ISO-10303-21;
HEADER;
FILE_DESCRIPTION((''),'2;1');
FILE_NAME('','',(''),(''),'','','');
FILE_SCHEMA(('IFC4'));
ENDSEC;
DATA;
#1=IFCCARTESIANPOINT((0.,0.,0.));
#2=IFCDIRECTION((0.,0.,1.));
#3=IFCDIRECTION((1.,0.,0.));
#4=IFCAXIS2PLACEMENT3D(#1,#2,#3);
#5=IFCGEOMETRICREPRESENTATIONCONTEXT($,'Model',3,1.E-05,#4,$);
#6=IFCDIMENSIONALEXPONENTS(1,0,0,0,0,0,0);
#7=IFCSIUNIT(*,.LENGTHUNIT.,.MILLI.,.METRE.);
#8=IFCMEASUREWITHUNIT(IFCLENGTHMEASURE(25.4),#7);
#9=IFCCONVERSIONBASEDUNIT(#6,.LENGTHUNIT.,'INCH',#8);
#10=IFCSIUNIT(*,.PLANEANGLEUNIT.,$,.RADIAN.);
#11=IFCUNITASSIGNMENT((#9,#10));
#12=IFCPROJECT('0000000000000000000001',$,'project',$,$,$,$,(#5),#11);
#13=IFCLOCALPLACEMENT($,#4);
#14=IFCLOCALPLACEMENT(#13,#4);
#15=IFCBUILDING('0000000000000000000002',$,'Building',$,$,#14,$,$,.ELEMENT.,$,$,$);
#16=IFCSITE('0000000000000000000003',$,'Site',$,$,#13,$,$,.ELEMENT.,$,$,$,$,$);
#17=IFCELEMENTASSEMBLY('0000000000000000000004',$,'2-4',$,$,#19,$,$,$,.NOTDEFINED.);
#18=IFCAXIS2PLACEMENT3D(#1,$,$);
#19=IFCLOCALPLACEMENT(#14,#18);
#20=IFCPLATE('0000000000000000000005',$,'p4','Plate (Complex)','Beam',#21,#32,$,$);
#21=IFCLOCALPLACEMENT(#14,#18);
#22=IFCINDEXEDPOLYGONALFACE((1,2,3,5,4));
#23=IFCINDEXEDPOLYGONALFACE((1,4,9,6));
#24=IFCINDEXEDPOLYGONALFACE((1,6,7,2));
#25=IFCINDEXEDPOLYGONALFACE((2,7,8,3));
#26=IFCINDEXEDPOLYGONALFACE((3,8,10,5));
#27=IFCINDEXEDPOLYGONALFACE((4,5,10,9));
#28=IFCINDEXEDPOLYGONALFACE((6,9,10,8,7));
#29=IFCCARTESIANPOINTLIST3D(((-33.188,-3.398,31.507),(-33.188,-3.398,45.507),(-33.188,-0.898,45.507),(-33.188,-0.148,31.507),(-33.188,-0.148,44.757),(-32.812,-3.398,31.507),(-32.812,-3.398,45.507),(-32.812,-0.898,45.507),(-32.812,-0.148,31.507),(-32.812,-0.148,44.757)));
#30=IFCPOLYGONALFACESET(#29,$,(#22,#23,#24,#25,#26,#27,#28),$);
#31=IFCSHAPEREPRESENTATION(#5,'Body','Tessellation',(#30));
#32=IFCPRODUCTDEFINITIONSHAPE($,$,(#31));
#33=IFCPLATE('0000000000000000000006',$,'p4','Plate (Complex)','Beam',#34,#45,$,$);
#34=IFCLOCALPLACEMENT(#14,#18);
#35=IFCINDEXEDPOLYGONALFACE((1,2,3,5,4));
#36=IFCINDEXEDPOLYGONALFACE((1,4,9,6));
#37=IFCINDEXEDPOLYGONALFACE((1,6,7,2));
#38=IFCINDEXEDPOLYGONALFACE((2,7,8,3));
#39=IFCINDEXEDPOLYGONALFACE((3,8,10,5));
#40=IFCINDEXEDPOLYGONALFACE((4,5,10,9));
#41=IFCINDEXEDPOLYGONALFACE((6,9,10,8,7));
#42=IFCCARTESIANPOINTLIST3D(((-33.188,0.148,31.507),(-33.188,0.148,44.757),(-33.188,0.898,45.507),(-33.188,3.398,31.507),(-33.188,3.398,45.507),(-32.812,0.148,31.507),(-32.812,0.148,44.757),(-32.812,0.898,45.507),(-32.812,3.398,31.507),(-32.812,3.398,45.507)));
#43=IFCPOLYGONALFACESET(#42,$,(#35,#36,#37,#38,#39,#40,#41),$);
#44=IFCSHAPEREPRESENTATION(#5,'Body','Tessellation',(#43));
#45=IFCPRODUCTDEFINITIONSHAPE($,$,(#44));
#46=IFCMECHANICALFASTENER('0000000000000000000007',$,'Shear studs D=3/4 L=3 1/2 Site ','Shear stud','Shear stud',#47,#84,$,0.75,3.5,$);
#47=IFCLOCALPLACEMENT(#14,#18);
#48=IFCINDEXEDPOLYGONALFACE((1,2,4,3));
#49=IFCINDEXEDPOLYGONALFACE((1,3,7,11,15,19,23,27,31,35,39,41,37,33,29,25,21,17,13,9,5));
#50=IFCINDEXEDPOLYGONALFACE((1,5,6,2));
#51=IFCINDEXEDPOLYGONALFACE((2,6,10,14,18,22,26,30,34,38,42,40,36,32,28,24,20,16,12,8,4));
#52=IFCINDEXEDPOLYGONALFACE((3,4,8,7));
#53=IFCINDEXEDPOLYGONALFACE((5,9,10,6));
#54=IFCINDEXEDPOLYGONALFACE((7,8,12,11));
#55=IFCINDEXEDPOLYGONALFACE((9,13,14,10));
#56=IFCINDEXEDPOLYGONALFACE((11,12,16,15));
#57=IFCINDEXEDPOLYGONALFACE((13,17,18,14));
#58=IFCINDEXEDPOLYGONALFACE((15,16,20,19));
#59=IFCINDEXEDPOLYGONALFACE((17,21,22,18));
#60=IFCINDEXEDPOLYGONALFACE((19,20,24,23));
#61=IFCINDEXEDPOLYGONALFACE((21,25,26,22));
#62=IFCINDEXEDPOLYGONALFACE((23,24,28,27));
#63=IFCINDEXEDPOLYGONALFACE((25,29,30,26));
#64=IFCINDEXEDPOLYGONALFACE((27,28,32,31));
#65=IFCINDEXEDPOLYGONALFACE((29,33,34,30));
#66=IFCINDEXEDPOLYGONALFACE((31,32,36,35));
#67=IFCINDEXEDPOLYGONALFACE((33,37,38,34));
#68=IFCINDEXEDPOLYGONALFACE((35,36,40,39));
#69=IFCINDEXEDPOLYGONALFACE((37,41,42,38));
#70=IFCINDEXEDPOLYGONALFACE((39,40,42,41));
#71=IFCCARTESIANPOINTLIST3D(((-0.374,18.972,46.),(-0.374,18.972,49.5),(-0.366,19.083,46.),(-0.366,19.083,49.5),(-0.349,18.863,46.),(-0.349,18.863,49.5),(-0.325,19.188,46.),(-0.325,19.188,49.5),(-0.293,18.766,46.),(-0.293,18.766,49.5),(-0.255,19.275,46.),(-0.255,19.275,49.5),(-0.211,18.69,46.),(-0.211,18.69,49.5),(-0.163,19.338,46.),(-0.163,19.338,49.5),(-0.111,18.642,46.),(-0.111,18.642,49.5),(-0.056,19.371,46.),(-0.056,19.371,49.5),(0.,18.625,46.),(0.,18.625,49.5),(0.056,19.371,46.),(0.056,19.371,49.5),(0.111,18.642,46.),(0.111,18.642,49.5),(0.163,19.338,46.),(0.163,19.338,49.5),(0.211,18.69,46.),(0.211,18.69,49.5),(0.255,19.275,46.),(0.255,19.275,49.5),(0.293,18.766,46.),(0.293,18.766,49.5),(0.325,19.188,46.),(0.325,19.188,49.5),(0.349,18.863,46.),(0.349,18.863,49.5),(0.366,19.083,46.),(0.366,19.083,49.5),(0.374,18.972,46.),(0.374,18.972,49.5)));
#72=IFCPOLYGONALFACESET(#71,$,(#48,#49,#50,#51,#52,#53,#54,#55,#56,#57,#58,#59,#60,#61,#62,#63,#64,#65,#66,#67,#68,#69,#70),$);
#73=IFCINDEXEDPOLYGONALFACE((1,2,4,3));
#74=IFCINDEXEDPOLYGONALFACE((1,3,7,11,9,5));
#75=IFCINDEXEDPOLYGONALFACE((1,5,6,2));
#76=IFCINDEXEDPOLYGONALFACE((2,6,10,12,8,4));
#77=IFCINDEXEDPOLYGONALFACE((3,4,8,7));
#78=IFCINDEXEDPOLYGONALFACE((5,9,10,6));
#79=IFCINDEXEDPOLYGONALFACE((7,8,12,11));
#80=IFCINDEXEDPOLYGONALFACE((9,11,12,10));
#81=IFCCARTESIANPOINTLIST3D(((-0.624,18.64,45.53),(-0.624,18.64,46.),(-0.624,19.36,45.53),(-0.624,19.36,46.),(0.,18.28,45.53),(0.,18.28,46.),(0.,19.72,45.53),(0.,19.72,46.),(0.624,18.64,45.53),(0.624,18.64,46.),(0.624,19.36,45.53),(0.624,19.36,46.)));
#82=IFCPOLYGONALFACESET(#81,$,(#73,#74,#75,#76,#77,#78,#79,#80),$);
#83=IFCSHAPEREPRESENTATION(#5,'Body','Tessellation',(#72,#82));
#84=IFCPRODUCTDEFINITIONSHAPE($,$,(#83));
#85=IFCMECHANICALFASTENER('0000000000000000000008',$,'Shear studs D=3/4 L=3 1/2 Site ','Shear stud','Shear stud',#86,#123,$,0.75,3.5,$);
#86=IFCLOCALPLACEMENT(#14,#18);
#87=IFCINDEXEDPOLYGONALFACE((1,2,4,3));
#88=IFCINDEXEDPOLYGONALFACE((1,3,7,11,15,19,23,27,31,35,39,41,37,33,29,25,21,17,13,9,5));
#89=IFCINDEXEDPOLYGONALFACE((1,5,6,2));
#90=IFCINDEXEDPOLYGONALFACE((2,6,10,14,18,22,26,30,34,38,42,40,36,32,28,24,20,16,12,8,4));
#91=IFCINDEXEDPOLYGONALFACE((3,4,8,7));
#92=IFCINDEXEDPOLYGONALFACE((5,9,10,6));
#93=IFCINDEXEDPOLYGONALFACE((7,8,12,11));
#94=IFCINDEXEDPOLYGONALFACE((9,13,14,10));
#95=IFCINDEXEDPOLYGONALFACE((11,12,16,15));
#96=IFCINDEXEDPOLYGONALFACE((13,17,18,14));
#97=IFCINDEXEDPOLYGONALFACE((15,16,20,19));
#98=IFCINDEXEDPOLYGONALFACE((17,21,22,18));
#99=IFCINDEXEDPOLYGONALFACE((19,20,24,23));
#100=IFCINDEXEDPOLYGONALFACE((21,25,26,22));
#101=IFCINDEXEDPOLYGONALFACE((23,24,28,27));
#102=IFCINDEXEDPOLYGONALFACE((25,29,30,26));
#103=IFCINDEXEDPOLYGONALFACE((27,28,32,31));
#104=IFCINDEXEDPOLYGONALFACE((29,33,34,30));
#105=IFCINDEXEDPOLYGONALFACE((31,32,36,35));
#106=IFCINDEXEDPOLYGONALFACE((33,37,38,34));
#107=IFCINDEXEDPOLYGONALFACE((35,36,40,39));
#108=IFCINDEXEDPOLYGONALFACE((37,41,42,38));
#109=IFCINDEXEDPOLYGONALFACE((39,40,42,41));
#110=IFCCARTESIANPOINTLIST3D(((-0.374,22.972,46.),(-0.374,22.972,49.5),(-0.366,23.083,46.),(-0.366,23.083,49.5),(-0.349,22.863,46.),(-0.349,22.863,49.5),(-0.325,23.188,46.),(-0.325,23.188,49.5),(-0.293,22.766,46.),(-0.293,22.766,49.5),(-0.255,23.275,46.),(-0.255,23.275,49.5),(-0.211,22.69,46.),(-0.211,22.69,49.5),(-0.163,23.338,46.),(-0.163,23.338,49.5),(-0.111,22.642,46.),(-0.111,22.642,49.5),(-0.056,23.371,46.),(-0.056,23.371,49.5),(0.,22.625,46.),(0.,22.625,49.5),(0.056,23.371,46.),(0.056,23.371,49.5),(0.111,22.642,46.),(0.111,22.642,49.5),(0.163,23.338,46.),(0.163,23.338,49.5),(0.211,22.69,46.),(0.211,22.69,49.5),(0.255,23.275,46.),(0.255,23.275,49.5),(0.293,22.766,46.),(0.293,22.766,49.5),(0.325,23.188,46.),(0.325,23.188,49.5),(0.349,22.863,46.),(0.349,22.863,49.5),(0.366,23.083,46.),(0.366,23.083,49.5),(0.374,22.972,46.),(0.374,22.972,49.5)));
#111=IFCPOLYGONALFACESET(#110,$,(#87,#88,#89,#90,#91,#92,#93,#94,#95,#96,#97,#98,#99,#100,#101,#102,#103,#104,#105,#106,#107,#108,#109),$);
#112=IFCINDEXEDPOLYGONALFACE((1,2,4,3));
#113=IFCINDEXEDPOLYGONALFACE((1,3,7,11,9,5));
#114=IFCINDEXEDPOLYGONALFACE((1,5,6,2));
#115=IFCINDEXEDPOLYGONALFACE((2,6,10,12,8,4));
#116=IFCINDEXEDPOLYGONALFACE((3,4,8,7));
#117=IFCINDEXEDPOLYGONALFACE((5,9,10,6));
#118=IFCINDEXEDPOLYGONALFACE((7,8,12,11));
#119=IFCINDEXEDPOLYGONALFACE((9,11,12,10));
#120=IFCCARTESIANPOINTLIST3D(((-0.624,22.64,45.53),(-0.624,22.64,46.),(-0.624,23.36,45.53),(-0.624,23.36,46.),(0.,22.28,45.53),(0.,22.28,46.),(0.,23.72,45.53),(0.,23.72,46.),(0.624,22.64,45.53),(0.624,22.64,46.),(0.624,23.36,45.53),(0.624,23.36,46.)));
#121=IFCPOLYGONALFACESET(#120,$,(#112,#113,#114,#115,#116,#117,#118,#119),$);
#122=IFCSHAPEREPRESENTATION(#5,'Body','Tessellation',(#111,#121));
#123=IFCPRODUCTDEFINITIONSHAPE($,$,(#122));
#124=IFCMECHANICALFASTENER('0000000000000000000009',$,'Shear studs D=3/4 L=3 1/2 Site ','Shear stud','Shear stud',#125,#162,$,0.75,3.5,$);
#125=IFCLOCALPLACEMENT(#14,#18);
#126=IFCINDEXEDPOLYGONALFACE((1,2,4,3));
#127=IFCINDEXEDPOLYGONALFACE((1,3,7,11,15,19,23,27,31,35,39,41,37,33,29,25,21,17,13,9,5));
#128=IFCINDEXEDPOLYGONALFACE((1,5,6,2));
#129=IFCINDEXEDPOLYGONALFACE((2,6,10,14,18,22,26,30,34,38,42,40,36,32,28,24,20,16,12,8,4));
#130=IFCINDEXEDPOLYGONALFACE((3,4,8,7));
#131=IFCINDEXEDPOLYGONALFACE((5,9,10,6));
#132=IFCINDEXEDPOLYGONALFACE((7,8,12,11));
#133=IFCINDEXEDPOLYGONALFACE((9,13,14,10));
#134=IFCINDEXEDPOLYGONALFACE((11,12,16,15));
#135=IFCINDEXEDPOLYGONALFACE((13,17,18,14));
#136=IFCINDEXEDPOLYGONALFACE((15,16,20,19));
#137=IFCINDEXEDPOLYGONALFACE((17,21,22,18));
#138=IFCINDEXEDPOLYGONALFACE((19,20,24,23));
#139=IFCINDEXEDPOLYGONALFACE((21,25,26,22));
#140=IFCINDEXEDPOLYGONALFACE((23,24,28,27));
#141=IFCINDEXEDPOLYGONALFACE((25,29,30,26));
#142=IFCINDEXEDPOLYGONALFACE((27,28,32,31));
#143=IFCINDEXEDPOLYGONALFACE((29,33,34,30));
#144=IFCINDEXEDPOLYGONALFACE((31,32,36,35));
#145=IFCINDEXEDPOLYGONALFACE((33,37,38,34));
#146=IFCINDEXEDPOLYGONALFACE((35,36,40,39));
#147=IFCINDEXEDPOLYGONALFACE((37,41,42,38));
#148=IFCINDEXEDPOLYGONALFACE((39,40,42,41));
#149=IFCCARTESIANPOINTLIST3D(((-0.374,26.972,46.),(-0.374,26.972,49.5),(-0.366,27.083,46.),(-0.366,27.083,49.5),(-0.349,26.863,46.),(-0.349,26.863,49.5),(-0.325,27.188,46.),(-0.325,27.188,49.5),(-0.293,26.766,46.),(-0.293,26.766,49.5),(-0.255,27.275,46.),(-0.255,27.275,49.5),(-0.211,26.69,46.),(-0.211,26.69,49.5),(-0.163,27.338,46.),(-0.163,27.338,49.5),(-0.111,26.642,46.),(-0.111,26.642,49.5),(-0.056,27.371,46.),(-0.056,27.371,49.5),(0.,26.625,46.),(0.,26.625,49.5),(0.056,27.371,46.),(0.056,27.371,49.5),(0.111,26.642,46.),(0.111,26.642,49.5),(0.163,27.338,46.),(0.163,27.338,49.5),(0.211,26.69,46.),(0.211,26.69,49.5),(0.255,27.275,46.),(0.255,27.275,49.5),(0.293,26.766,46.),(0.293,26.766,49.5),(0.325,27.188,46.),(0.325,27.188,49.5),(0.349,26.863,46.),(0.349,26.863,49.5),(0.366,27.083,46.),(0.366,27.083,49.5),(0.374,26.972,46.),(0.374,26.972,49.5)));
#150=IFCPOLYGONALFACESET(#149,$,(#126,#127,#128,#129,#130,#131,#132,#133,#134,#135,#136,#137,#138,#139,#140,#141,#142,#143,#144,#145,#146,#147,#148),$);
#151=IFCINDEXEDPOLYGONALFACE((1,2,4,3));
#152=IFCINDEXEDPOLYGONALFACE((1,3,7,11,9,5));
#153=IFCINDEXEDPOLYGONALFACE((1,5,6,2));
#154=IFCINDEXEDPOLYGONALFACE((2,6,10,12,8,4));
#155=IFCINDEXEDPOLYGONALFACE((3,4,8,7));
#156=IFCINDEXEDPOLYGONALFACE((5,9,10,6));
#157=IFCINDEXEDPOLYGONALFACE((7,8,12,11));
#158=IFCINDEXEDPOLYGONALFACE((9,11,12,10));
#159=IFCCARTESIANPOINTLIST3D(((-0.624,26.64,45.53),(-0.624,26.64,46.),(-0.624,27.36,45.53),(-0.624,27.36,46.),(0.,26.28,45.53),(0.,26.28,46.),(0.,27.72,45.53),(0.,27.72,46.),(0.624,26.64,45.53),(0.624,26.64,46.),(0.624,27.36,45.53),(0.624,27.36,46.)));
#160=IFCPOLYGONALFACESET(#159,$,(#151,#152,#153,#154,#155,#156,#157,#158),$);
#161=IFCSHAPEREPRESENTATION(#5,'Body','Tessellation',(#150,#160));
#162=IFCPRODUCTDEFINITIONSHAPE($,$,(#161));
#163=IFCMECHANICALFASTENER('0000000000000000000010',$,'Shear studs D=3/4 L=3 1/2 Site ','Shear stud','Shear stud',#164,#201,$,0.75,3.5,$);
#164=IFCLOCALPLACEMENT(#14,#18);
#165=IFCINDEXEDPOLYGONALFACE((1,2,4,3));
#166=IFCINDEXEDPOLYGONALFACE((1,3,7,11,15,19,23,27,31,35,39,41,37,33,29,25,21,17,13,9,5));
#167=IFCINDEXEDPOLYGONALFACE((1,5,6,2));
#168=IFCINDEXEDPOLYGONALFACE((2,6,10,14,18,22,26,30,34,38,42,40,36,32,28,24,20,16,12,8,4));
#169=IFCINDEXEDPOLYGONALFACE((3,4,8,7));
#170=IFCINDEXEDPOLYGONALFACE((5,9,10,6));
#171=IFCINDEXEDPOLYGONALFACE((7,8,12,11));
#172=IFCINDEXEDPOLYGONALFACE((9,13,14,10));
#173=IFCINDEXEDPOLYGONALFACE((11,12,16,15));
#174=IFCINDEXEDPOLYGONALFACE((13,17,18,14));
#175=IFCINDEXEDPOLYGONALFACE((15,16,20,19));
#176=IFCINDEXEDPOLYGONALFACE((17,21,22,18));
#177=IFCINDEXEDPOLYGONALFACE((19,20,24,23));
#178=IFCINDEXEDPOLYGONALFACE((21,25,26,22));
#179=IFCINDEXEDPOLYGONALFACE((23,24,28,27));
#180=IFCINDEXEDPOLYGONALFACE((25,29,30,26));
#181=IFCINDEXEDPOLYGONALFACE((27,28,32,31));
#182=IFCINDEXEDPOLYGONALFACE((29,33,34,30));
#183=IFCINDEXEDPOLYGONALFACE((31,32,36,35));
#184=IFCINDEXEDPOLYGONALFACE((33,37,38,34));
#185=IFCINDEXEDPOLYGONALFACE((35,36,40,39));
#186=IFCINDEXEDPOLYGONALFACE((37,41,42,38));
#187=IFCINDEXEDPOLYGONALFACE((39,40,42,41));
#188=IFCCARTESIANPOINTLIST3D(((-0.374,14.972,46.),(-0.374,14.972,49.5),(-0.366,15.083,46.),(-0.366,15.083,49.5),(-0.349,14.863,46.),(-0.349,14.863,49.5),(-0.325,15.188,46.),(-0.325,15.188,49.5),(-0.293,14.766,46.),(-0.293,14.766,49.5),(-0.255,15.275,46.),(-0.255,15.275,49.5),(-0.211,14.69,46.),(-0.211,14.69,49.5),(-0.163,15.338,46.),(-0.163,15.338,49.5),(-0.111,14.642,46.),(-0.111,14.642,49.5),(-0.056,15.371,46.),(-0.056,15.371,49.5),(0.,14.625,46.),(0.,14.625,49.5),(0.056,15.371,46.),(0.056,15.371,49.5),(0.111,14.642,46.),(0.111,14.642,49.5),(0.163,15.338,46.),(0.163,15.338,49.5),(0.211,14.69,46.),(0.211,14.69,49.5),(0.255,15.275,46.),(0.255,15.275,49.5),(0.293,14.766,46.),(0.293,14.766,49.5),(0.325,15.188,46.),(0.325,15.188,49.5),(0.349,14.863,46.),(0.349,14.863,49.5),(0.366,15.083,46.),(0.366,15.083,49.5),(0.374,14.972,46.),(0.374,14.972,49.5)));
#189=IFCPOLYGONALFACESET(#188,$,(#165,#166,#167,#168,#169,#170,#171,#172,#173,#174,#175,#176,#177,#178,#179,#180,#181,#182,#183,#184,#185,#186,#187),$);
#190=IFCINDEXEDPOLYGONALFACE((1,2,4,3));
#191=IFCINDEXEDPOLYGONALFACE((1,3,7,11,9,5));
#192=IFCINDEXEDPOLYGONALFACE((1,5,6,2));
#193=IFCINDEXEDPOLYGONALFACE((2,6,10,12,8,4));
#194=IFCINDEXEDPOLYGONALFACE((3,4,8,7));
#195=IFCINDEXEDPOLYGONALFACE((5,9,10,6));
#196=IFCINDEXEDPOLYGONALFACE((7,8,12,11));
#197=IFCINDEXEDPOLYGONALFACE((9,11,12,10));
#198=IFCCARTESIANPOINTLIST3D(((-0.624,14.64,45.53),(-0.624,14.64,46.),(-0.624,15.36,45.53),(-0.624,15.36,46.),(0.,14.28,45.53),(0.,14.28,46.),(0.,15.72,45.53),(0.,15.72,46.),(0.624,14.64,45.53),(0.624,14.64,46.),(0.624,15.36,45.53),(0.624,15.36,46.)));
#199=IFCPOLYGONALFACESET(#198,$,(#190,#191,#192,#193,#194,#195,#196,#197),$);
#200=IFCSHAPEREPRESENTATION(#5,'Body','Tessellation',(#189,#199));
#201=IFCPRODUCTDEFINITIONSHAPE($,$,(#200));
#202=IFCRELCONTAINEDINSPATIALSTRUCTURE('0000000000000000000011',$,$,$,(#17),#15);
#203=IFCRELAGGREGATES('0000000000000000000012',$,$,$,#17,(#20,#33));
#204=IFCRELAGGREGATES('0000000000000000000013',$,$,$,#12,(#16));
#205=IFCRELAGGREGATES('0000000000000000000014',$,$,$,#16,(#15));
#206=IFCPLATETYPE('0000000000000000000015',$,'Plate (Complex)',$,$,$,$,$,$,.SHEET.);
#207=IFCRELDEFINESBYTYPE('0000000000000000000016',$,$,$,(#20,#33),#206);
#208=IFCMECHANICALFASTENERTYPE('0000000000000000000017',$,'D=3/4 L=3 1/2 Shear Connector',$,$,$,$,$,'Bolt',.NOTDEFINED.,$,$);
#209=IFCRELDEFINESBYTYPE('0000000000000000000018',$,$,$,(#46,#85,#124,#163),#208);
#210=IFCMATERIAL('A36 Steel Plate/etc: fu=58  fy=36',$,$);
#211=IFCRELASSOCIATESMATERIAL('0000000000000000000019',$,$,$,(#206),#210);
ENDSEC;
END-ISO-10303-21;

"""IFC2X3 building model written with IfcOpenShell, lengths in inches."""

from ifc_helpers import new_model, entity, si_unit, converted_unit, frame, origin_with_axes, origin_2d_with_axis, place, context, project, spatial, polyline, circle, outline, extrude, source, transform, mapped, material, type_object, type_shapes, element, aggregate, save


model = new_model("IFC2X3")

# Units and contexts
model_context = context("Model", 3, precision=1e-05, world=origin_with_axes())
ifc_project = project(units=[converted_unit("LENGTHUNIT", "INCH", entity("IfcLengthMeasure", 25.4), si_unit("LENGTHUNIT", "METRE", prefix="MILLI"), dimensions=[1, 0, 0, 0, 0, 0, 0]), si_unit("PLANEANGLEUNIT", "RADIAN")], contexts=[model_context])

# Site, building
site_placement = place(None, origin_with_axes())
site = spatial("IfcSite", under=ifc_project, at=site_placement, Name="Site", CompositionType="ELEMENT")
building_placement = place(site_placement, origin_with_axes())
building = spatial("IfcBuilding", under=site, at=building_placement, Name="Building", CompositionType="ELEMENT")

# Shared definitions
assembly_1_placement = place(building_placement, frame((0.0, 0.0, 46.0), z_axis=(0.0, 0.0, 1.0), x_axis=(0.0, 1.0, 0.0)))

# Element assembly
assembly_2_placement = place(building_placement, frame((0.0, 0.0, 46.0), z_axis=(0.0, 0.0, 1.0), x_axis=(-1.0, 0.0, 0.0)))
assembly_2 = element("IfcElementAssembly", 1, at=assembly_2_placement, inside=building, Name="2-4", PredefinedType="NOTDEFINED")

# Shared definitions
ifc_material_1 = material(Name="A36 Steel Plate/etc: fu=58  fy=36")

# Plates
plate_type_1 = type_object("IfcPlateType", Name="Plate (Complex)", PredefinedType="SHEET", material=ifc_material_1)
shared_shape_1 = source(origin_with_axes(), model_context, "Body", "SweptSolid", [
    extrude(outline(polyline([(0.0, -14.0), (-3.25, -14.0), (-3.25, 0.0), (-0.75, 0.0), (0.0, -0.75), (0.0, -14.0)])), frame((-0.188, 0.0, 0.0), z_axis=(1.0, 0.0, 0.0), x_axis=(0.0, 1.0, 0.0)), (0.0, 0.0, 1.0), 0.375),
])
type_shapes(plate_type_1, [shared_shape_1])
plate_1_placement = place(assembly_2_placement, frame((33.0, 0.148, -0.493), z_axis=(0.0, 0.0, 1.0), x_axis=(-1.0, 0.0, 0.0)))
plate_1 = element("IfcPlate", 2, at=plate_1_placement, type_object=plate_type_1, Name="p4", Description="Plate (Complex)", ObjectType="Beam", context=model_context, shape_type="MappedRepresentation", body=[
    mapped(shared_shape_1, transform((0.0, 0.0, 0.0), scale=1.0)),
])
plate_2_placement = place(assembly_2_placement, frame((33.0, -0.148, -0.493), z_axis=(0.0, 0.0, 1.0), x_axis=(1.0, 0.0, 0.0)))
plate_2 = element("IfcPlate", 3, at=plate_2_placement, type_object=plate_type_1, Name="p4", Description="Plate (Complex)", ObjectType="Beam", context=model_context, shape_type="MappedRepresentation", body=[
    mapped(shared_shape_1, transform((0.0, 0.0, 0.0), scale=1.0)),
])
aggregate(assembly_2, [plate_1, plate_2])

# Mechanical fasteners
mechanical_fastener_type_1 = type_object("IfcMechanicalFastenerType", Name="D=3/4 L=3 1/2 Shear Connector", ElementType="Bolt")
shared_shape_2 = source(origin_with_axes(), model_context, "Body", "SweptSolid", [
    extrude(circle(Radius=0.375, at=origin_2d_with_axis()), frame((0.0, 0.0, 0.0), z_axis=(1.0, 0.0, 0.0), x_axis=(0.0, 1.0, 0.0)), (0.0, 0.0, 1.0), 3.5),
    extrude(outline(polyline([(-0.72, 0.0), (-0.36, 0.624), (0.36, 0.624), (0.72, 0.0), (0.36, -0.624), (-0.36, -0.624), (-0.72, 0.0)])), frame((0.0, 0.0, 0.0), z_axis=(1.0, 0.0, 0.0), x_axis=(0.0, 1.0, 0.0)), (0.0, 0.0, -1.0), 0.47),
])
type_shapes(mechanical_fastener_type_1, [shared_shape_2])
placement_1 = place(assembly_1_placement, frame((19.0, 0.0, 0.0), z_axis=(0.0, -1.0, 0.0), x_axis=(0.0, 0.0, 1.0)))
mechanical_fastener_1_placement = place(placement_1, origin_with_axes())
element("IfcMechanicalFastener", 4, at=mechanical_fastener_1_placement, type_object=mechanical_fastener_type_1, Name="Shear studs D=3/4 L=3 1/2 Site ", Description="Shear stud", ObjectType="Shear stud", NominalDiameter=0.75, NominalLength=3.5, context=model_context, shape_type="MappedRepresentation", body=[
    mapped(shared_shape_2, transform((0.0, 0.0, 0.0), scale=1.0)),
])
placement_2 = place(assembly_1_placement, frame((23.0, 0.0, 0.0), z_axis=(0.0, -1.0, 0.0), x_axis=(0.0, 0.0, 1.0)))
mechanical_fastener_2_placement = place(placement_2, origin_with_axes())
element("IfcMechanicalFastener", 5, at=mechanical_fastener_2_placement, type_object=mechanical_fastener_type_1, Name="Shear studs D=3/4 L=3 1/2 Site ", Description="Shear stud", ObjectType="Shear stud", NominalDiameter=0.75, NominalLength=3.5, context=model_context, shape_type="MappedRepresentation", body=[
    mapped(shared_shape_2, transform((0.0, 0.0, 0.0), scale=1.0)),
])
placement_3 = place(assembly_1_placement, frame((27.0, 0.0, 0.0), z_axis=(0.0, -1.0, 0.0), x_axis=(0.0, 0.0, 1.0)))
mechanical_fastener_3_placement = place(placement_3, origin_with_axes())
element("IfcMechanicalFastener", 6, at=mechanical_fastener_3_placement, type_object=mechanical_fastener_type_1, Name="Shear studs D=3/4 L=3 1/2 Site ", Description="Shear stud", ObjectType="Shear stud", NominalDiameter=0.75, NominalLength=3.5, context=model_context, shape_type="MappedRepresentation", body=[
    mapped(shared_shape_2, transform((0.0, 0.0, 0.0), scale=1.0)),
])
placement_4 = place(assembly_1_placement, frame((15.0, 0.0, 0.0), z_axis=(0.0, -1.0, 0.0), x_axis=(0.0, 0.0, 1.0)))
mechanical_fastener_4_placement = place(placement_4, origin_with_axes())
element("IfcMechanicalFastener", 7, at=mechanical_fastener_4_placement, type_object=mechanical_fastener_type_1, Name="Shear studs D=3/4 L=3 1/2 Site ", Description="Shear stud", ObjectType="Shear stud", NominalDiameter=0.75, NominalLength=3.5, context=model_context, shape_type="MappedRepresentation", body=[
    mapped(shared_shape_2, transform((0.0, 0.0, 0.0), scale=1.0)),
])

save(model, "model.ifc")
